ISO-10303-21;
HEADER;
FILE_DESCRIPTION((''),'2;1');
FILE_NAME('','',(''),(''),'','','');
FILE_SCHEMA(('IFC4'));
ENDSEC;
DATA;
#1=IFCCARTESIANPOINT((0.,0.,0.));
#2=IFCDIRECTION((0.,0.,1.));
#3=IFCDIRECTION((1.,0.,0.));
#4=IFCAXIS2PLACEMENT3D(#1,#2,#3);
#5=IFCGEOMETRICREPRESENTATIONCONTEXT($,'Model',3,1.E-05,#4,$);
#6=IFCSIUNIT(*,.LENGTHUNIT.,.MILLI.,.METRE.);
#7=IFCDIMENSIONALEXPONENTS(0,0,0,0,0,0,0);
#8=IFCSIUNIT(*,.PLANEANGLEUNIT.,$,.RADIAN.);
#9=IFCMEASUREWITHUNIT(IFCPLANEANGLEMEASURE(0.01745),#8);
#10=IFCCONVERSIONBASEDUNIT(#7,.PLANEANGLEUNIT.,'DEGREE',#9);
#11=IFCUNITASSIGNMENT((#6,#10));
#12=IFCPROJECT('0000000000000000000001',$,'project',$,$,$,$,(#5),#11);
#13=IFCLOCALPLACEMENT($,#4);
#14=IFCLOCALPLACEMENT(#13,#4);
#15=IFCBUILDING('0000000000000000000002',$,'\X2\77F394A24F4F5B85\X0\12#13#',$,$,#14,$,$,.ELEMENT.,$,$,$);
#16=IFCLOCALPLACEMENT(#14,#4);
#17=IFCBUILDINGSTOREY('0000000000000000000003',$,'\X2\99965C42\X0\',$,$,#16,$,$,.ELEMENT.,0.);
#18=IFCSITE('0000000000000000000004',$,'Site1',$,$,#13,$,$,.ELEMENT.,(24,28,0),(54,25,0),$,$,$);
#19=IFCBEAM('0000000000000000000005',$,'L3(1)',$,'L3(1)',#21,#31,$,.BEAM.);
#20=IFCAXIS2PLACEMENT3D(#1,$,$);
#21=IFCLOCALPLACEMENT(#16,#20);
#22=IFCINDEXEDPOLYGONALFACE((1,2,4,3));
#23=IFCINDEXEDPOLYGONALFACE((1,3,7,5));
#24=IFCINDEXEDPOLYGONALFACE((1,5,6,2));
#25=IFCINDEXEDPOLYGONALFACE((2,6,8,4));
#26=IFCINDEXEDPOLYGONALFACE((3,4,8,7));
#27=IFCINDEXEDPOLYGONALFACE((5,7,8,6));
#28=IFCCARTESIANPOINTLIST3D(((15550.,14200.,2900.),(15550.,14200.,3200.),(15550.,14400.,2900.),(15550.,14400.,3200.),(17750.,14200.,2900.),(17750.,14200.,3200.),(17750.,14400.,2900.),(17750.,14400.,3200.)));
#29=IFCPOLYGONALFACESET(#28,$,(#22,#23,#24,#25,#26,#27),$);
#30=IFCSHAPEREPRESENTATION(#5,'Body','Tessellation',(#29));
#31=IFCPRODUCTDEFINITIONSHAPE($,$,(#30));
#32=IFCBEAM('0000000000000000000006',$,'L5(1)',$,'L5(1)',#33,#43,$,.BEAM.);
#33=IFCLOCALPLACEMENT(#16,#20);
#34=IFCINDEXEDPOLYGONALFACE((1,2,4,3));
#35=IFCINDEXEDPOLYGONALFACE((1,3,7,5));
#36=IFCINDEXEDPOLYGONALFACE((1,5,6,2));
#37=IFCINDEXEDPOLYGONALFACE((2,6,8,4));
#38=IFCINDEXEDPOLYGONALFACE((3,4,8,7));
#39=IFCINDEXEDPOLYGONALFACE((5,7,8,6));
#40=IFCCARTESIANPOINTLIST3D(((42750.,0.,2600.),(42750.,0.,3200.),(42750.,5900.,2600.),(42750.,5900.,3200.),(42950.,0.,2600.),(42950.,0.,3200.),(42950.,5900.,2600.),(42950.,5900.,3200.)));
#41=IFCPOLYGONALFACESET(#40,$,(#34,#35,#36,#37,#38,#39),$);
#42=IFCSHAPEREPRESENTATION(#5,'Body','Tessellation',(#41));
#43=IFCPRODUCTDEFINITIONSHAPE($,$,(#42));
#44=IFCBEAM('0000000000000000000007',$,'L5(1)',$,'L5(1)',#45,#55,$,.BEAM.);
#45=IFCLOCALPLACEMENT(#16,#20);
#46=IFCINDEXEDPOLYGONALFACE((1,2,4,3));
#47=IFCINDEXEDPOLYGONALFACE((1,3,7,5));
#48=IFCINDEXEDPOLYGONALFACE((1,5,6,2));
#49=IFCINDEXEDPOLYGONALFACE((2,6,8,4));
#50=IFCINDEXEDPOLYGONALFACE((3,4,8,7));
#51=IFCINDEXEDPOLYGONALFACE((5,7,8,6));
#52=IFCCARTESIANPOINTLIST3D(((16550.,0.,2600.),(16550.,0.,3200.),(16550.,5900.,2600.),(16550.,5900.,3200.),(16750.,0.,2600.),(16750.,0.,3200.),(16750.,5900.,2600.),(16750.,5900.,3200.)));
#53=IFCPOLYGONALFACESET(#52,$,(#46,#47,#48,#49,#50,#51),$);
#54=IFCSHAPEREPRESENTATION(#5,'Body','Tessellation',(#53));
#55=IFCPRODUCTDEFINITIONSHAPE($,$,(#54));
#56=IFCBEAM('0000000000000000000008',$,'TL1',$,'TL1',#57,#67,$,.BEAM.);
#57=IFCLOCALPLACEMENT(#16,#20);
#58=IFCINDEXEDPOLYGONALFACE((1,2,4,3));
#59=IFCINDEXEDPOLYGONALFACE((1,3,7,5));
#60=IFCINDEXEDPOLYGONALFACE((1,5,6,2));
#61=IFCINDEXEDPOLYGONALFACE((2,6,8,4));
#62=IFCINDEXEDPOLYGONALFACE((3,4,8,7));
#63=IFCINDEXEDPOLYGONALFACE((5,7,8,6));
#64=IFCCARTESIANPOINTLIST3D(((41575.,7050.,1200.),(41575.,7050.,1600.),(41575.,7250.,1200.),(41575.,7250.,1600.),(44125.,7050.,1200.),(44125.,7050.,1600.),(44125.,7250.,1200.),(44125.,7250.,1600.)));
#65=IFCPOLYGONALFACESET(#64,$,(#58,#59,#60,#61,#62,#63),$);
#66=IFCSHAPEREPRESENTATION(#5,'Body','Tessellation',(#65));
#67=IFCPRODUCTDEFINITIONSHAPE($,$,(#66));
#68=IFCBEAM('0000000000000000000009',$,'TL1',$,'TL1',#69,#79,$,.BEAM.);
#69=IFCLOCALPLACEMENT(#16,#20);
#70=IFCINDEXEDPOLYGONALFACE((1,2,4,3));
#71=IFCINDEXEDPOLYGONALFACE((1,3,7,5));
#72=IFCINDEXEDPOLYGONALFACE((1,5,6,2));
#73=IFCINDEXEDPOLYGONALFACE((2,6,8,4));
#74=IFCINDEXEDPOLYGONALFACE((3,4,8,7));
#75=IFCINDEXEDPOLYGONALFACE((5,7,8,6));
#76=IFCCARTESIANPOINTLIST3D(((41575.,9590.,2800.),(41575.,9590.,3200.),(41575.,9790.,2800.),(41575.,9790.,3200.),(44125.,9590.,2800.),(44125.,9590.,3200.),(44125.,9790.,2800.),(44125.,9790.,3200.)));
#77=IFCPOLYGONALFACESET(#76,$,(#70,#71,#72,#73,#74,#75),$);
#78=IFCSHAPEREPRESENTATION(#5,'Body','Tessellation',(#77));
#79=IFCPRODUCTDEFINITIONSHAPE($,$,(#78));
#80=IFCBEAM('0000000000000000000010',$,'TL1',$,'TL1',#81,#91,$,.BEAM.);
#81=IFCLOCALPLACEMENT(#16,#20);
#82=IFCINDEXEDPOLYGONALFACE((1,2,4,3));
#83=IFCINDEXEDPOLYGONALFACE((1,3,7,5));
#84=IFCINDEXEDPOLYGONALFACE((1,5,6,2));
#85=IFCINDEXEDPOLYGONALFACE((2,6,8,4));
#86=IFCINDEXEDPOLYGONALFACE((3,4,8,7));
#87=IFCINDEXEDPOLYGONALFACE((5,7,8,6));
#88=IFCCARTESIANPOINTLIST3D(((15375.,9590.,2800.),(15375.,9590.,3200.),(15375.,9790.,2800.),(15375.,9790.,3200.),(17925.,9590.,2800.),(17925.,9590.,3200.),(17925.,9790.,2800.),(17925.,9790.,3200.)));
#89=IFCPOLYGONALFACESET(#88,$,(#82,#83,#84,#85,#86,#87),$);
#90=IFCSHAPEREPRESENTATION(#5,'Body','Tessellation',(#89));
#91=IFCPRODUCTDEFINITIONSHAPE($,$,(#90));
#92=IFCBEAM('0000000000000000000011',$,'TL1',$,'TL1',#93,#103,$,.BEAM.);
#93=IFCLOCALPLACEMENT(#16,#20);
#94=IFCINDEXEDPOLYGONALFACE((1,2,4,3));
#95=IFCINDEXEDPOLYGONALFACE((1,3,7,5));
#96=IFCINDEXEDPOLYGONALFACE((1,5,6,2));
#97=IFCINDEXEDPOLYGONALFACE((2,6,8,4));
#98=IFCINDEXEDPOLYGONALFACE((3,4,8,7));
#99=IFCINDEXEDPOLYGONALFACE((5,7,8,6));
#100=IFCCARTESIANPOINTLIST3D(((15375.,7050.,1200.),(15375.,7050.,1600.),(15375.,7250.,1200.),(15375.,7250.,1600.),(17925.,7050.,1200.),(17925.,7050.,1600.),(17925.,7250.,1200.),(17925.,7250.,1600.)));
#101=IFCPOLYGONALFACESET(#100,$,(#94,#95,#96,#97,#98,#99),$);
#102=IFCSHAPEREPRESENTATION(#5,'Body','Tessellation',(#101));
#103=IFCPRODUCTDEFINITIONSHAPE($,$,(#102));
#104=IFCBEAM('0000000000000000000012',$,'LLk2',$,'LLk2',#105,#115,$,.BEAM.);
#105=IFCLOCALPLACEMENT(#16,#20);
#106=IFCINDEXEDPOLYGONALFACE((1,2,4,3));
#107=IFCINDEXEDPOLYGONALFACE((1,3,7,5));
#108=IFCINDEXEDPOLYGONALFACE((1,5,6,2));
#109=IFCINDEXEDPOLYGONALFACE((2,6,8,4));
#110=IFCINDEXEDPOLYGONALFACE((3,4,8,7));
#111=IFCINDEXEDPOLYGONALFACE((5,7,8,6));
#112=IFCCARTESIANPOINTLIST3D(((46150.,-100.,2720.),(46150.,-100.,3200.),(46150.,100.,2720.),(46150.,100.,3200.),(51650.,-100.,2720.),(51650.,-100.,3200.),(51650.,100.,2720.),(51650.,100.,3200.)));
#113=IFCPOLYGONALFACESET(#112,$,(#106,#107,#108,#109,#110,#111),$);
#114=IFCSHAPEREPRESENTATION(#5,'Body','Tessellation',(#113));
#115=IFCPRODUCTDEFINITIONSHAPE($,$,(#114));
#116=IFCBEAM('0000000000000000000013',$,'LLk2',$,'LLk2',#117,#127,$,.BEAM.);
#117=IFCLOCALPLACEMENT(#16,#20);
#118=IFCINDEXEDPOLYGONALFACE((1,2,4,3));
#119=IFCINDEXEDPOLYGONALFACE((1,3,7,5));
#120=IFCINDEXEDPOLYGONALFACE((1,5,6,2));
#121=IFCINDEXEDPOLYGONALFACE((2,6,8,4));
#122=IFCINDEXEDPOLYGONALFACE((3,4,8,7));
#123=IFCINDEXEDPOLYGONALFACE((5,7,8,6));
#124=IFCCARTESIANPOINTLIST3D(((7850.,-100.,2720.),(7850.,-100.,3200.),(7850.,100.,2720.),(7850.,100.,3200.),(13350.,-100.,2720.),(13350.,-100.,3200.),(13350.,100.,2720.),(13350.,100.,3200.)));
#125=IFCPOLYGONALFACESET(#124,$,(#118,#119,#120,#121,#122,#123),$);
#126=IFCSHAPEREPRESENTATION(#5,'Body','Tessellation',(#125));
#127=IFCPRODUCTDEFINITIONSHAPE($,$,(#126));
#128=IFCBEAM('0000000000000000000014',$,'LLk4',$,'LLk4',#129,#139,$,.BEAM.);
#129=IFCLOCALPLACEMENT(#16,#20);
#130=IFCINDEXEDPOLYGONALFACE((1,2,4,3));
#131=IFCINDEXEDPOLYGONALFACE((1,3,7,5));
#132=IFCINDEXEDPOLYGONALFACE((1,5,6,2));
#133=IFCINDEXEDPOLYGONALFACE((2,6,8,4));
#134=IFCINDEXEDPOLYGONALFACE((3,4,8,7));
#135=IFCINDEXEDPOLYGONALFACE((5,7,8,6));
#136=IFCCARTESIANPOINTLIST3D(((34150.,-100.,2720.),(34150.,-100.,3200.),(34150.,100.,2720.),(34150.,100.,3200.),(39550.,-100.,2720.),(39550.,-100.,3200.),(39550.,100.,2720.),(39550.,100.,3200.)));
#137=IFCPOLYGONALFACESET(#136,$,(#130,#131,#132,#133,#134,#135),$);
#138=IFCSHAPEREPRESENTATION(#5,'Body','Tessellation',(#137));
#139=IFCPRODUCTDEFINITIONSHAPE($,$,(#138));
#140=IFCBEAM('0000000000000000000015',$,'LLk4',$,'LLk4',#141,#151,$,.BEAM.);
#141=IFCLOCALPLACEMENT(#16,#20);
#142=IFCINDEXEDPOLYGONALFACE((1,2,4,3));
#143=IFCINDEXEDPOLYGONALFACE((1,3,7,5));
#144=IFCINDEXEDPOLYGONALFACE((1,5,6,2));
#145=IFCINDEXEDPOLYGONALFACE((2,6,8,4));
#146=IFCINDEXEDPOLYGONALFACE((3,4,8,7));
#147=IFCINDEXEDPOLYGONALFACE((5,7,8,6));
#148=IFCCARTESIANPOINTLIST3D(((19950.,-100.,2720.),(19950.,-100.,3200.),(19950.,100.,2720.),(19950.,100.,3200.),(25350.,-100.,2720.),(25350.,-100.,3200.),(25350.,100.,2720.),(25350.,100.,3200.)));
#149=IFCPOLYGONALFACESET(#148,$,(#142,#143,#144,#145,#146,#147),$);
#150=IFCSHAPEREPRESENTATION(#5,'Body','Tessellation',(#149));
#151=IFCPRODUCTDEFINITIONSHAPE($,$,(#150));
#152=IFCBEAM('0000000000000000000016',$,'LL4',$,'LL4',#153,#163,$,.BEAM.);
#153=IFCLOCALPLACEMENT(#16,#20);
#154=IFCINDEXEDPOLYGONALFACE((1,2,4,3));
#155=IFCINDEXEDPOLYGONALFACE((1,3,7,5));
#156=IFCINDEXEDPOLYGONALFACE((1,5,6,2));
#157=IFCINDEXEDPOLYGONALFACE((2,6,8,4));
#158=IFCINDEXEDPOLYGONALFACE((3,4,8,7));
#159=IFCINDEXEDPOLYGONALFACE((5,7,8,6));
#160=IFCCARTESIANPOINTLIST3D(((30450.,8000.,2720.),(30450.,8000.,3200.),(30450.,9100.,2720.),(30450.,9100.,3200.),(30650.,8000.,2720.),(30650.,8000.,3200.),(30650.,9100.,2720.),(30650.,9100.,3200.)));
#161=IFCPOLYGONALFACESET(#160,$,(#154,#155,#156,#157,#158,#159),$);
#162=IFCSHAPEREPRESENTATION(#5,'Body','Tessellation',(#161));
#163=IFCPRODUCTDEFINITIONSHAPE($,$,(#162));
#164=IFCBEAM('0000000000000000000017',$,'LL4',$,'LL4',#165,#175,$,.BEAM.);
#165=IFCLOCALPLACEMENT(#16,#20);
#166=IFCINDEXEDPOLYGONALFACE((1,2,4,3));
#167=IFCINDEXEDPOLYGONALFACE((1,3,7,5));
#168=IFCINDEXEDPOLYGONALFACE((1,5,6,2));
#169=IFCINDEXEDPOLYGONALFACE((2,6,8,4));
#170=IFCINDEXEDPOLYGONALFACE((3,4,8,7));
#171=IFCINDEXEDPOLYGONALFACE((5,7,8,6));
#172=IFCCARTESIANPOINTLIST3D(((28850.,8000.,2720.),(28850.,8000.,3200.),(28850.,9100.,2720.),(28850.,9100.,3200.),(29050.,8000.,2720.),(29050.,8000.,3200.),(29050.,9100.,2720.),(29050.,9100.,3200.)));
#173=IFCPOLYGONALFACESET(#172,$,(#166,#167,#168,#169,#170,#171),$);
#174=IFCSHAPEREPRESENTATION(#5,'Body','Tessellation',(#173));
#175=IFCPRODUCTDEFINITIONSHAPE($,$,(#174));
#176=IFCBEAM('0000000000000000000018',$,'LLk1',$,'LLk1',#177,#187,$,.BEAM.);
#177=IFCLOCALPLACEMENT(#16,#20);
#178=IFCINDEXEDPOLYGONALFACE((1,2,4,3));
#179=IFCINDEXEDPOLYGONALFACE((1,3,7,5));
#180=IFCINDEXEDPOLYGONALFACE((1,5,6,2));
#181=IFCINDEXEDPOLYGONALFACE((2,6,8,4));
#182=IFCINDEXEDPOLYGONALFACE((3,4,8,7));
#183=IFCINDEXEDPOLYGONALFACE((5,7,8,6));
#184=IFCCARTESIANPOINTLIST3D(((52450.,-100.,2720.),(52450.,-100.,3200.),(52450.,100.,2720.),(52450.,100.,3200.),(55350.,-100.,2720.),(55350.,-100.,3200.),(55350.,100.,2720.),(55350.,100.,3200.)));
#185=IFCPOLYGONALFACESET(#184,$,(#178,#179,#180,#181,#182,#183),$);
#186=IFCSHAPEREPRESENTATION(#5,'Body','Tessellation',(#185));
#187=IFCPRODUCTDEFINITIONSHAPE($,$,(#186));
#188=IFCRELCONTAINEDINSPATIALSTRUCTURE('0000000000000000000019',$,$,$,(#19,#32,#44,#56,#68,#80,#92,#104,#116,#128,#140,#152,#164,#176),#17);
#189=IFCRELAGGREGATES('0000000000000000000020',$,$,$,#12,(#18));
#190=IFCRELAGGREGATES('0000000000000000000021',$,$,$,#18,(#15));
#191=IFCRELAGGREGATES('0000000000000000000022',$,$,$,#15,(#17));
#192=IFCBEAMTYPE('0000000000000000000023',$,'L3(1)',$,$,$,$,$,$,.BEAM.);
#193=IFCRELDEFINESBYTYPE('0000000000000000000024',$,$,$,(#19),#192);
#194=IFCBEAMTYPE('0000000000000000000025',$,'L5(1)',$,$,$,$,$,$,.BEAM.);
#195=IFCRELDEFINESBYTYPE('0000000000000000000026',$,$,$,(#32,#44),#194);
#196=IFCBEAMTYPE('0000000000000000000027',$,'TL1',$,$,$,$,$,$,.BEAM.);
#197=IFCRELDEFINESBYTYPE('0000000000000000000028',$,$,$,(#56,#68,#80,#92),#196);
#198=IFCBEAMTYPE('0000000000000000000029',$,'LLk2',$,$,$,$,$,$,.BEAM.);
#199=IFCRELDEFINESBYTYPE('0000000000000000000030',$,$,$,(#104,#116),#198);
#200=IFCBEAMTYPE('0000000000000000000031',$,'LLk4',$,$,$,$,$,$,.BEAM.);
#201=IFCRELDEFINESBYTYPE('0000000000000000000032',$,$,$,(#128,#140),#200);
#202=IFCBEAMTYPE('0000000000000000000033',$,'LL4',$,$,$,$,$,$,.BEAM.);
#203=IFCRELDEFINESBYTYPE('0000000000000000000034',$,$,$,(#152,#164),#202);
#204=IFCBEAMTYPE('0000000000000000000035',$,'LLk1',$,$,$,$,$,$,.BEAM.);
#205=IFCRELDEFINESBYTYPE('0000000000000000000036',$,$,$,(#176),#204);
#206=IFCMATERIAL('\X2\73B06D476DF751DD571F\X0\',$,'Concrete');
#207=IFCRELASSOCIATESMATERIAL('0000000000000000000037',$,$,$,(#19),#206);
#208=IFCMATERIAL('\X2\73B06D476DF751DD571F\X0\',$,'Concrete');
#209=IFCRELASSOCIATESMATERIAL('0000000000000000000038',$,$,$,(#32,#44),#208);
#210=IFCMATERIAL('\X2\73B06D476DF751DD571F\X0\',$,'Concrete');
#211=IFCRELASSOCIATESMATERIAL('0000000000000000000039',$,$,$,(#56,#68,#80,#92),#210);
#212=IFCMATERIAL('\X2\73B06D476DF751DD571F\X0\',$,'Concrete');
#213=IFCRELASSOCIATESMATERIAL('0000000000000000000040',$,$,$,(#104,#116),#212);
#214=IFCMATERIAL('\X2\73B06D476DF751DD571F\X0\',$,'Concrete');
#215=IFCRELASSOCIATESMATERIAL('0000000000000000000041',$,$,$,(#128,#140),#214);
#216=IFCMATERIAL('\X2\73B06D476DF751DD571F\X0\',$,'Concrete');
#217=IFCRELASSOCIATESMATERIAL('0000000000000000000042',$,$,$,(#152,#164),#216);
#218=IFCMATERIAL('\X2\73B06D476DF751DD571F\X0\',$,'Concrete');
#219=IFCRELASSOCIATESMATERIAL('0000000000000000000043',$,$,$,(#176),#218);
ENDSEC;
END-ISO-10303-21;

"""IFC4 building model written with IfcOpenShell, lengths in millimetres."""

from ifc_helpers import new_model, entity, si_unit, converted_unit, frame, origin_with_axes, place, context, project, spatial, polyline, outline, extrude, material, type_object, element, save


model = new_model("IFC4")

# Units and contexts
model_context = context("Model", 3, precision=1e-05, world=origin_with_axes())
ifc_project = project(units=[si_unit("LENGTHUNIT", "METRE", prefix="MILLI"), converted_unit("PLANEANGLEUNIT", "DEGREE", entity("IfcPlaneAngleMeasure", 0.01745), si_unit("PLANEANGLEUNIT", "RADIAN"), dimensions=[0, 0, 0, 0, 0, 0, 0])], contexts=[model_context])

# Site, building, storey
site_placement = place(None, origin_with_axes())
site = spatial("IfcSite", under=ifc_project, at=site_placement, Name="Site1", CompositionType="ELEMENT", RefLatitude=(24, 28, 0), RefLongitude=(54, 25, 0))
building_placement = place(site_placement, origin_with_axes())
building = spatial("IfcBuilding", under=site, at=building_placement, Name="石钢住宅12#13#", CompositionType="ELEMENT")
storey_placement = place(building_placement, origin_with_axes())
storey = spatial("IfcBuildingStorey", under=building, at=storey_placement, Name="首层", CompositionType="ELEMENT", Elevation=0.0)

# Beams
ifc_material_1 = material(Name="现浇混凝土", Category="Concrete")
beam_type_1 = type_object("IfcBeamType", Name="L3(1)", PredefinedType="BEAM")
beam_1_placement = place(storey_placement, origin_with_axes())
element("IfcBeam", 1, at=beam_1_placement, inside=storey, type_object=beam_type_1, material=ifc_material_1, Name="L3(1)", ObjectType="L3(1)", PredefinedType="BEAM", context=model_context, shape_type="SweptSolid", body=[
    extrude(outline(polyline([(0.0, 0.0), (300.0, 0.0), (300.0, 200.0), (0.0, 200.0), (0.0, 0.0)])), frame((15550.0, 14400.0, 2900.0), z_axis=(1.0, 0.0, 0.0), x_axis=(0.0, 0.0, 1.0)), (0.0, 0.0, 1.0), 2200.0),
])
ifc_material_2 = material(Name="现浇混凝土", Category="Concrete")
beam_type_2 = type_object("IfcBeamType", Name="L5(1)", PredefinedType="BEAM")
beam_2_placement = place(storey_placement, origin_with_axes())
element("IfcBeam", 2, at=beam_2_placement, inside=storey, type_object=beam_type_2, material=ifc_material_2, Name="L5(1)", ObjectType="L5(1)", PredefinedType="BEAM", context=model_context, shape_type="SweptSolid", body=[
    extrude(outline(polyline([(0.0, 0.0), (200.0, 0.0), (200.0, 600.0), (0.0, 600.0), (0.0, 0.0)])), frame((42950.0, 0.0, 2600.0), z_axis=(0.0, 1.0, 0.0), x_axis=(-1.0, 0.0, 0.0)), (0.0, 0.0, 1.0), 5900.0),
])
beam_3_placement = place(storey_placement, origin_with_axes())
element("IfcBeam", 3, at=beam_3_placement, inside=storey, type_object=beam_type_2, material=ifc_material_2, Name="L5(1)", ObjectType="L5(1)", PredefinedType="BEAM", context=model_context, shape_type="SweptSolid", body=[
    extrude(outline(polyline([(0.0, 0.0), (600.0, 0.0), (600.0, 200.0), (0.0, 200.0), (0.0, 0.0)])), frame((16550.0, 0.0, 2600.0), z_axis=(0.0, 1.0, 0.0), x_axis=(0.0, 0.0, 1.0)), (0.0, 0.0, 1.0), 5900.0),
])
ifc_material_3 = material(Name="现浇混凝土", Category="Concrete")
beam_type_3 = type_object("IfcBeamType", Name="TL1", PredefinedType="BEAM")
beam_4_placement = place(storey_placement, origin_with_axes())
element("IfcBeam", 4, at=beam_4_placement, inside=storey, type_object=beam_type_3, material=ifc_material_3, Name="TL1", ObjectType="TL1", PredefinedType="BEAM", context=model_context, shape_type="SweptSolid", body=[
    extrude(outline(polyline([(0.0, 0.0), (200.0, 0.0), (200.0, 400.0), (0.0, 400.0), (0.0, 0.0)])), frame((44125.0, 7250.0, 1200.0), z_axis=(-1.0, 0.0, 0.0), x_axis=(0.0, -1.0, 0.0)), (0.0, 0.0, 1.0), 2550.0),
])
beam_5_placement = place(storey_placement, origin_with_axes())
element("IfcBeam", 5, at=beam_5_placement, inside=storey, type_object=beam_type_3, material=ifc_material_3, Name="TL1", ObjectType="TL1", PredefinedType="BEAM", context=model_context, shape_type="SweptSolid", body=[
    extrude(outline(polyline([(0.0, 0.0), (200.0, 0.0), (200.0, 400.0), (0.0, 400.0), (0.0, 0.0)])), frame((44125.0, 9790.0, 2800.0), z_axis=(-1.0, 0.0, 0.0), x_axis=(0.0, -1.0, 0.0)), (0.0, 0.0, 1.0), 2550.0),
])
beam_6_placement = place(storey_placement, origin_with_axes())
element("IfcBeam", 6, at=beam_6_placement, inside=storey, type_object=beam_type_3, material=ifc_material_3, Name="TL1", ObjectType="TL1", PredefinedType="BEAM", context=model_context, shape_type="SweptSolid", body=[
    extrude(outline(polyline([(0.0, 0.0), (400.0, 0.0), (400.0, 200.0), (0.0, 200.0), (0.0, 0.0)])), frame((15375.0, 9790.0, 2800.0), z_axis=(1.0, 0.0, 0.0), x_axis=(0.0, 0.0, 1.0)), (0.0, 0.0, 1.0), 2550.0),
])
beam_7_placement = place(storey_placement, origin_with_axes())
element("IfcBeam", 7, at=beam_7_placement, inside=storey, type_object=beam_type_3, material=ifc_material_3, Name="TL1", ObjectType="TL1", PredefinedType="BEAM", context=model_context, shape_type="SweptSolid", body=[
    extrude(outline(polyline([(0.0, 0.0), (400.0, 0.0), (400.0, 200.0), (0.0, 200.0), (0.0, 0.0)])), frame((15375.0, 7250.0, 1200.0), z_axis=(1.0, 0.0, 0.0), x_axis=(0.0, 0.0, 1.0)), (0.0, 0.0, 1.0), 2550.0),
])
ifc_material_4 = material(Name="现浇混凝土", Category="Concrete")
beam_type_4 = type_object("IfcBeamType", Name="LLk2", PredefinedType="BEAM")
beam_8_placement = place(storey_placement, origin_with_axes())
element("IfcBeam", 8, at=beam_8_placement, inside=storey, type_object=beam_type_4, material=ifc_material_4, Name="LLk2", ObjectType="LLk2", PredefinedType="BEAM", context=model_context, shape_type="SweptSolid", body=[
    extrude(outline(polyline([(0.0, 0.0), (200.0, 0.0), (200.0, 480.0), (0.0, 480.0), (0.0, 0.0)])), frame((51650.0, 100.0, 2720.0), z_axis=(-1.0, 0.0, 0.0), x_axis=(0.0, -1.0, 0.0)), (0.0, 0.0, 1.0), 5500.0),
])
beam_9_placement = place(storey_placement, origin_with_axes())
element("IfcBeam", 9, at=beam_9_placement, inside=storey, type_object=beam_type_4, material=ifc_material_4, Name="LLk2", ObjectType="LLk2", PredefinedType="BEAM", context=model_context, shape_type="SweptSolid", body=[
    extrude(outline(polyline([(0.0, 0.0), (480.0, 0.0), (480.0, 200.0), (0.0, 200.0), (0.0, 0.0)])), frame((7850.0, 100.0, 2720.0), z_axis=(1.0, 0.0, 0.0), x_axis=(0.0, 0.0, 1.0)), (0.0, 0.0, 1.0), 5500.0),
])
ifc_material_5 = material(Name="现浇混凝土", Category="Concrete")
beam_type_5 = type_object("IfcBeamType", Name="LLk4", PredefinedType="BEAM")
beam_10_placement = place(storey_placement, origin_with_axes())
element("IfcBeam", 10, at=beam_10_placement, inside=storey, type_object=beam_type_5, material=ifc_material_5, Name="LLk4", ObjectType="LLk4", PredefinedType="BEAM", context=model_context, shape_type="SweptSolid", body=[
    extrude(outline(polyline([(0.0, 0.0), (200.0, 0.0), (200.0, 480.0), (0.0, 480.0), (0.0, 0.0)])), frame((39550.0, 100.0, 2720.0), z_axis=(-1.0, 0.0, 0.0), x_axis=(0.0, -1.0, 0.0)), (0.0, 0.0, 1.0), 5400.0),
])
beam_11_placement = place(storey_placement, origin_with_axes())
element("IfcBeam", 11, at=beam_11_placement, inside=storey, type_object=beam_type_5, material=ifc_material_5, Name="LLk4", ObjectType="LLk4", PredefinedType="BEAM", context=model_context, shape_type="SweptSolid", body=[
    extrude(outline(polyline([(0.0, 0.0), (480.0, 0.0), (480.0, 200.0), (0.0, 200.0), (0.0, 0.0)])), frame((19950.0, 100.0, 2720.0), z_axis=(1.0, 0.0, 0.0), x_axis=(0.0, 0.0, 1.0)), (0.0, 0.0, 1.0), 5400.0),
])
ifc_material_6 = material(Name="现浇混凝土", Category="Concrete")
beam_type_6 = type_object("IfcBeamType", Name="LL4", PredefinedType="BEAM")
beam_12_placement = place(storey_placement, origin_with_axes())
element("IfcBeam", 12, at=beam_12_placement, inside=storey, type_object=beam_type_6, material=ifc_material_6, Name="LL4", ObjectType="LL4", PredefinedType="BEAM", context=model_context, shape_type="SweptSolid", body=[
    extrude(outline(polyline([(0.0, 0.0), (200.0, 0.0), (200.0, 480.0), (0.0, 480.0), (0.0, 0.0)])), frame((30650.0, 8000.0, 2720.0), z_axis=(0.0, 1.0, 0.0), x_axis=(-1.0, 0.0, 0.0)), (0.0, 0.0, 1.0), 1100.0),
])
beam_13_placement = place(storey_placement, origin_with_axes())
element("IfcBeam", 13, at=beam_13_placement, inside=storey, type_object=beam_type_6, material=ifc_material_6, Name="LL4", ObjectType="LL4", PredefinedType="BEAM", context=model_context, shape_type="SweptSolid", body=[
    extrude(outline(polyline([(0.0, 0.0), (480.0, 0.0), (480.0, 200.0), (0.0, 200.0), (0.0, 0.0)])), frame((28850.0, 8000.0, 2720.0), z_axis=(0.0, 1.0, 0.0), x_axis=(0.0, 0.0, 1.0)), (0.0, 0.0, 1.0), 1100.0),
])
ifc_material_7 = material(Name="现浇混凝土", Category="Concrete")
beam_type_7 = type_object("IfcBeamType", Name="LLk1", PredefinedType="BEAM")
beam_14_placement = place(storey_placement, origin_with_axes())
element("IfcBeam", 14, at=beam_14_placement, inside=storey, type_object=beam_type_7, material=ifc_material_7, Name="LLk1", ObjectType="LLk1", PredefinedType="BEAM", context=model_context, shape_type="SweptSolid", body=[
    extrude(outline(polyline([(0.0, 0.0), (200.0, 0.0), (200.0, 480.0), (0.0, 480.0), (0.0, 0.0)])), frame((55350.0, 100.0, 2720.0), z_axis=(-1.0, 0.0, 0.0), x_axis=(0.0, -1.0, 0.0)), (0.0, 0.0, 1.0), 2900.0),
])

save(model, "model.ifc")
